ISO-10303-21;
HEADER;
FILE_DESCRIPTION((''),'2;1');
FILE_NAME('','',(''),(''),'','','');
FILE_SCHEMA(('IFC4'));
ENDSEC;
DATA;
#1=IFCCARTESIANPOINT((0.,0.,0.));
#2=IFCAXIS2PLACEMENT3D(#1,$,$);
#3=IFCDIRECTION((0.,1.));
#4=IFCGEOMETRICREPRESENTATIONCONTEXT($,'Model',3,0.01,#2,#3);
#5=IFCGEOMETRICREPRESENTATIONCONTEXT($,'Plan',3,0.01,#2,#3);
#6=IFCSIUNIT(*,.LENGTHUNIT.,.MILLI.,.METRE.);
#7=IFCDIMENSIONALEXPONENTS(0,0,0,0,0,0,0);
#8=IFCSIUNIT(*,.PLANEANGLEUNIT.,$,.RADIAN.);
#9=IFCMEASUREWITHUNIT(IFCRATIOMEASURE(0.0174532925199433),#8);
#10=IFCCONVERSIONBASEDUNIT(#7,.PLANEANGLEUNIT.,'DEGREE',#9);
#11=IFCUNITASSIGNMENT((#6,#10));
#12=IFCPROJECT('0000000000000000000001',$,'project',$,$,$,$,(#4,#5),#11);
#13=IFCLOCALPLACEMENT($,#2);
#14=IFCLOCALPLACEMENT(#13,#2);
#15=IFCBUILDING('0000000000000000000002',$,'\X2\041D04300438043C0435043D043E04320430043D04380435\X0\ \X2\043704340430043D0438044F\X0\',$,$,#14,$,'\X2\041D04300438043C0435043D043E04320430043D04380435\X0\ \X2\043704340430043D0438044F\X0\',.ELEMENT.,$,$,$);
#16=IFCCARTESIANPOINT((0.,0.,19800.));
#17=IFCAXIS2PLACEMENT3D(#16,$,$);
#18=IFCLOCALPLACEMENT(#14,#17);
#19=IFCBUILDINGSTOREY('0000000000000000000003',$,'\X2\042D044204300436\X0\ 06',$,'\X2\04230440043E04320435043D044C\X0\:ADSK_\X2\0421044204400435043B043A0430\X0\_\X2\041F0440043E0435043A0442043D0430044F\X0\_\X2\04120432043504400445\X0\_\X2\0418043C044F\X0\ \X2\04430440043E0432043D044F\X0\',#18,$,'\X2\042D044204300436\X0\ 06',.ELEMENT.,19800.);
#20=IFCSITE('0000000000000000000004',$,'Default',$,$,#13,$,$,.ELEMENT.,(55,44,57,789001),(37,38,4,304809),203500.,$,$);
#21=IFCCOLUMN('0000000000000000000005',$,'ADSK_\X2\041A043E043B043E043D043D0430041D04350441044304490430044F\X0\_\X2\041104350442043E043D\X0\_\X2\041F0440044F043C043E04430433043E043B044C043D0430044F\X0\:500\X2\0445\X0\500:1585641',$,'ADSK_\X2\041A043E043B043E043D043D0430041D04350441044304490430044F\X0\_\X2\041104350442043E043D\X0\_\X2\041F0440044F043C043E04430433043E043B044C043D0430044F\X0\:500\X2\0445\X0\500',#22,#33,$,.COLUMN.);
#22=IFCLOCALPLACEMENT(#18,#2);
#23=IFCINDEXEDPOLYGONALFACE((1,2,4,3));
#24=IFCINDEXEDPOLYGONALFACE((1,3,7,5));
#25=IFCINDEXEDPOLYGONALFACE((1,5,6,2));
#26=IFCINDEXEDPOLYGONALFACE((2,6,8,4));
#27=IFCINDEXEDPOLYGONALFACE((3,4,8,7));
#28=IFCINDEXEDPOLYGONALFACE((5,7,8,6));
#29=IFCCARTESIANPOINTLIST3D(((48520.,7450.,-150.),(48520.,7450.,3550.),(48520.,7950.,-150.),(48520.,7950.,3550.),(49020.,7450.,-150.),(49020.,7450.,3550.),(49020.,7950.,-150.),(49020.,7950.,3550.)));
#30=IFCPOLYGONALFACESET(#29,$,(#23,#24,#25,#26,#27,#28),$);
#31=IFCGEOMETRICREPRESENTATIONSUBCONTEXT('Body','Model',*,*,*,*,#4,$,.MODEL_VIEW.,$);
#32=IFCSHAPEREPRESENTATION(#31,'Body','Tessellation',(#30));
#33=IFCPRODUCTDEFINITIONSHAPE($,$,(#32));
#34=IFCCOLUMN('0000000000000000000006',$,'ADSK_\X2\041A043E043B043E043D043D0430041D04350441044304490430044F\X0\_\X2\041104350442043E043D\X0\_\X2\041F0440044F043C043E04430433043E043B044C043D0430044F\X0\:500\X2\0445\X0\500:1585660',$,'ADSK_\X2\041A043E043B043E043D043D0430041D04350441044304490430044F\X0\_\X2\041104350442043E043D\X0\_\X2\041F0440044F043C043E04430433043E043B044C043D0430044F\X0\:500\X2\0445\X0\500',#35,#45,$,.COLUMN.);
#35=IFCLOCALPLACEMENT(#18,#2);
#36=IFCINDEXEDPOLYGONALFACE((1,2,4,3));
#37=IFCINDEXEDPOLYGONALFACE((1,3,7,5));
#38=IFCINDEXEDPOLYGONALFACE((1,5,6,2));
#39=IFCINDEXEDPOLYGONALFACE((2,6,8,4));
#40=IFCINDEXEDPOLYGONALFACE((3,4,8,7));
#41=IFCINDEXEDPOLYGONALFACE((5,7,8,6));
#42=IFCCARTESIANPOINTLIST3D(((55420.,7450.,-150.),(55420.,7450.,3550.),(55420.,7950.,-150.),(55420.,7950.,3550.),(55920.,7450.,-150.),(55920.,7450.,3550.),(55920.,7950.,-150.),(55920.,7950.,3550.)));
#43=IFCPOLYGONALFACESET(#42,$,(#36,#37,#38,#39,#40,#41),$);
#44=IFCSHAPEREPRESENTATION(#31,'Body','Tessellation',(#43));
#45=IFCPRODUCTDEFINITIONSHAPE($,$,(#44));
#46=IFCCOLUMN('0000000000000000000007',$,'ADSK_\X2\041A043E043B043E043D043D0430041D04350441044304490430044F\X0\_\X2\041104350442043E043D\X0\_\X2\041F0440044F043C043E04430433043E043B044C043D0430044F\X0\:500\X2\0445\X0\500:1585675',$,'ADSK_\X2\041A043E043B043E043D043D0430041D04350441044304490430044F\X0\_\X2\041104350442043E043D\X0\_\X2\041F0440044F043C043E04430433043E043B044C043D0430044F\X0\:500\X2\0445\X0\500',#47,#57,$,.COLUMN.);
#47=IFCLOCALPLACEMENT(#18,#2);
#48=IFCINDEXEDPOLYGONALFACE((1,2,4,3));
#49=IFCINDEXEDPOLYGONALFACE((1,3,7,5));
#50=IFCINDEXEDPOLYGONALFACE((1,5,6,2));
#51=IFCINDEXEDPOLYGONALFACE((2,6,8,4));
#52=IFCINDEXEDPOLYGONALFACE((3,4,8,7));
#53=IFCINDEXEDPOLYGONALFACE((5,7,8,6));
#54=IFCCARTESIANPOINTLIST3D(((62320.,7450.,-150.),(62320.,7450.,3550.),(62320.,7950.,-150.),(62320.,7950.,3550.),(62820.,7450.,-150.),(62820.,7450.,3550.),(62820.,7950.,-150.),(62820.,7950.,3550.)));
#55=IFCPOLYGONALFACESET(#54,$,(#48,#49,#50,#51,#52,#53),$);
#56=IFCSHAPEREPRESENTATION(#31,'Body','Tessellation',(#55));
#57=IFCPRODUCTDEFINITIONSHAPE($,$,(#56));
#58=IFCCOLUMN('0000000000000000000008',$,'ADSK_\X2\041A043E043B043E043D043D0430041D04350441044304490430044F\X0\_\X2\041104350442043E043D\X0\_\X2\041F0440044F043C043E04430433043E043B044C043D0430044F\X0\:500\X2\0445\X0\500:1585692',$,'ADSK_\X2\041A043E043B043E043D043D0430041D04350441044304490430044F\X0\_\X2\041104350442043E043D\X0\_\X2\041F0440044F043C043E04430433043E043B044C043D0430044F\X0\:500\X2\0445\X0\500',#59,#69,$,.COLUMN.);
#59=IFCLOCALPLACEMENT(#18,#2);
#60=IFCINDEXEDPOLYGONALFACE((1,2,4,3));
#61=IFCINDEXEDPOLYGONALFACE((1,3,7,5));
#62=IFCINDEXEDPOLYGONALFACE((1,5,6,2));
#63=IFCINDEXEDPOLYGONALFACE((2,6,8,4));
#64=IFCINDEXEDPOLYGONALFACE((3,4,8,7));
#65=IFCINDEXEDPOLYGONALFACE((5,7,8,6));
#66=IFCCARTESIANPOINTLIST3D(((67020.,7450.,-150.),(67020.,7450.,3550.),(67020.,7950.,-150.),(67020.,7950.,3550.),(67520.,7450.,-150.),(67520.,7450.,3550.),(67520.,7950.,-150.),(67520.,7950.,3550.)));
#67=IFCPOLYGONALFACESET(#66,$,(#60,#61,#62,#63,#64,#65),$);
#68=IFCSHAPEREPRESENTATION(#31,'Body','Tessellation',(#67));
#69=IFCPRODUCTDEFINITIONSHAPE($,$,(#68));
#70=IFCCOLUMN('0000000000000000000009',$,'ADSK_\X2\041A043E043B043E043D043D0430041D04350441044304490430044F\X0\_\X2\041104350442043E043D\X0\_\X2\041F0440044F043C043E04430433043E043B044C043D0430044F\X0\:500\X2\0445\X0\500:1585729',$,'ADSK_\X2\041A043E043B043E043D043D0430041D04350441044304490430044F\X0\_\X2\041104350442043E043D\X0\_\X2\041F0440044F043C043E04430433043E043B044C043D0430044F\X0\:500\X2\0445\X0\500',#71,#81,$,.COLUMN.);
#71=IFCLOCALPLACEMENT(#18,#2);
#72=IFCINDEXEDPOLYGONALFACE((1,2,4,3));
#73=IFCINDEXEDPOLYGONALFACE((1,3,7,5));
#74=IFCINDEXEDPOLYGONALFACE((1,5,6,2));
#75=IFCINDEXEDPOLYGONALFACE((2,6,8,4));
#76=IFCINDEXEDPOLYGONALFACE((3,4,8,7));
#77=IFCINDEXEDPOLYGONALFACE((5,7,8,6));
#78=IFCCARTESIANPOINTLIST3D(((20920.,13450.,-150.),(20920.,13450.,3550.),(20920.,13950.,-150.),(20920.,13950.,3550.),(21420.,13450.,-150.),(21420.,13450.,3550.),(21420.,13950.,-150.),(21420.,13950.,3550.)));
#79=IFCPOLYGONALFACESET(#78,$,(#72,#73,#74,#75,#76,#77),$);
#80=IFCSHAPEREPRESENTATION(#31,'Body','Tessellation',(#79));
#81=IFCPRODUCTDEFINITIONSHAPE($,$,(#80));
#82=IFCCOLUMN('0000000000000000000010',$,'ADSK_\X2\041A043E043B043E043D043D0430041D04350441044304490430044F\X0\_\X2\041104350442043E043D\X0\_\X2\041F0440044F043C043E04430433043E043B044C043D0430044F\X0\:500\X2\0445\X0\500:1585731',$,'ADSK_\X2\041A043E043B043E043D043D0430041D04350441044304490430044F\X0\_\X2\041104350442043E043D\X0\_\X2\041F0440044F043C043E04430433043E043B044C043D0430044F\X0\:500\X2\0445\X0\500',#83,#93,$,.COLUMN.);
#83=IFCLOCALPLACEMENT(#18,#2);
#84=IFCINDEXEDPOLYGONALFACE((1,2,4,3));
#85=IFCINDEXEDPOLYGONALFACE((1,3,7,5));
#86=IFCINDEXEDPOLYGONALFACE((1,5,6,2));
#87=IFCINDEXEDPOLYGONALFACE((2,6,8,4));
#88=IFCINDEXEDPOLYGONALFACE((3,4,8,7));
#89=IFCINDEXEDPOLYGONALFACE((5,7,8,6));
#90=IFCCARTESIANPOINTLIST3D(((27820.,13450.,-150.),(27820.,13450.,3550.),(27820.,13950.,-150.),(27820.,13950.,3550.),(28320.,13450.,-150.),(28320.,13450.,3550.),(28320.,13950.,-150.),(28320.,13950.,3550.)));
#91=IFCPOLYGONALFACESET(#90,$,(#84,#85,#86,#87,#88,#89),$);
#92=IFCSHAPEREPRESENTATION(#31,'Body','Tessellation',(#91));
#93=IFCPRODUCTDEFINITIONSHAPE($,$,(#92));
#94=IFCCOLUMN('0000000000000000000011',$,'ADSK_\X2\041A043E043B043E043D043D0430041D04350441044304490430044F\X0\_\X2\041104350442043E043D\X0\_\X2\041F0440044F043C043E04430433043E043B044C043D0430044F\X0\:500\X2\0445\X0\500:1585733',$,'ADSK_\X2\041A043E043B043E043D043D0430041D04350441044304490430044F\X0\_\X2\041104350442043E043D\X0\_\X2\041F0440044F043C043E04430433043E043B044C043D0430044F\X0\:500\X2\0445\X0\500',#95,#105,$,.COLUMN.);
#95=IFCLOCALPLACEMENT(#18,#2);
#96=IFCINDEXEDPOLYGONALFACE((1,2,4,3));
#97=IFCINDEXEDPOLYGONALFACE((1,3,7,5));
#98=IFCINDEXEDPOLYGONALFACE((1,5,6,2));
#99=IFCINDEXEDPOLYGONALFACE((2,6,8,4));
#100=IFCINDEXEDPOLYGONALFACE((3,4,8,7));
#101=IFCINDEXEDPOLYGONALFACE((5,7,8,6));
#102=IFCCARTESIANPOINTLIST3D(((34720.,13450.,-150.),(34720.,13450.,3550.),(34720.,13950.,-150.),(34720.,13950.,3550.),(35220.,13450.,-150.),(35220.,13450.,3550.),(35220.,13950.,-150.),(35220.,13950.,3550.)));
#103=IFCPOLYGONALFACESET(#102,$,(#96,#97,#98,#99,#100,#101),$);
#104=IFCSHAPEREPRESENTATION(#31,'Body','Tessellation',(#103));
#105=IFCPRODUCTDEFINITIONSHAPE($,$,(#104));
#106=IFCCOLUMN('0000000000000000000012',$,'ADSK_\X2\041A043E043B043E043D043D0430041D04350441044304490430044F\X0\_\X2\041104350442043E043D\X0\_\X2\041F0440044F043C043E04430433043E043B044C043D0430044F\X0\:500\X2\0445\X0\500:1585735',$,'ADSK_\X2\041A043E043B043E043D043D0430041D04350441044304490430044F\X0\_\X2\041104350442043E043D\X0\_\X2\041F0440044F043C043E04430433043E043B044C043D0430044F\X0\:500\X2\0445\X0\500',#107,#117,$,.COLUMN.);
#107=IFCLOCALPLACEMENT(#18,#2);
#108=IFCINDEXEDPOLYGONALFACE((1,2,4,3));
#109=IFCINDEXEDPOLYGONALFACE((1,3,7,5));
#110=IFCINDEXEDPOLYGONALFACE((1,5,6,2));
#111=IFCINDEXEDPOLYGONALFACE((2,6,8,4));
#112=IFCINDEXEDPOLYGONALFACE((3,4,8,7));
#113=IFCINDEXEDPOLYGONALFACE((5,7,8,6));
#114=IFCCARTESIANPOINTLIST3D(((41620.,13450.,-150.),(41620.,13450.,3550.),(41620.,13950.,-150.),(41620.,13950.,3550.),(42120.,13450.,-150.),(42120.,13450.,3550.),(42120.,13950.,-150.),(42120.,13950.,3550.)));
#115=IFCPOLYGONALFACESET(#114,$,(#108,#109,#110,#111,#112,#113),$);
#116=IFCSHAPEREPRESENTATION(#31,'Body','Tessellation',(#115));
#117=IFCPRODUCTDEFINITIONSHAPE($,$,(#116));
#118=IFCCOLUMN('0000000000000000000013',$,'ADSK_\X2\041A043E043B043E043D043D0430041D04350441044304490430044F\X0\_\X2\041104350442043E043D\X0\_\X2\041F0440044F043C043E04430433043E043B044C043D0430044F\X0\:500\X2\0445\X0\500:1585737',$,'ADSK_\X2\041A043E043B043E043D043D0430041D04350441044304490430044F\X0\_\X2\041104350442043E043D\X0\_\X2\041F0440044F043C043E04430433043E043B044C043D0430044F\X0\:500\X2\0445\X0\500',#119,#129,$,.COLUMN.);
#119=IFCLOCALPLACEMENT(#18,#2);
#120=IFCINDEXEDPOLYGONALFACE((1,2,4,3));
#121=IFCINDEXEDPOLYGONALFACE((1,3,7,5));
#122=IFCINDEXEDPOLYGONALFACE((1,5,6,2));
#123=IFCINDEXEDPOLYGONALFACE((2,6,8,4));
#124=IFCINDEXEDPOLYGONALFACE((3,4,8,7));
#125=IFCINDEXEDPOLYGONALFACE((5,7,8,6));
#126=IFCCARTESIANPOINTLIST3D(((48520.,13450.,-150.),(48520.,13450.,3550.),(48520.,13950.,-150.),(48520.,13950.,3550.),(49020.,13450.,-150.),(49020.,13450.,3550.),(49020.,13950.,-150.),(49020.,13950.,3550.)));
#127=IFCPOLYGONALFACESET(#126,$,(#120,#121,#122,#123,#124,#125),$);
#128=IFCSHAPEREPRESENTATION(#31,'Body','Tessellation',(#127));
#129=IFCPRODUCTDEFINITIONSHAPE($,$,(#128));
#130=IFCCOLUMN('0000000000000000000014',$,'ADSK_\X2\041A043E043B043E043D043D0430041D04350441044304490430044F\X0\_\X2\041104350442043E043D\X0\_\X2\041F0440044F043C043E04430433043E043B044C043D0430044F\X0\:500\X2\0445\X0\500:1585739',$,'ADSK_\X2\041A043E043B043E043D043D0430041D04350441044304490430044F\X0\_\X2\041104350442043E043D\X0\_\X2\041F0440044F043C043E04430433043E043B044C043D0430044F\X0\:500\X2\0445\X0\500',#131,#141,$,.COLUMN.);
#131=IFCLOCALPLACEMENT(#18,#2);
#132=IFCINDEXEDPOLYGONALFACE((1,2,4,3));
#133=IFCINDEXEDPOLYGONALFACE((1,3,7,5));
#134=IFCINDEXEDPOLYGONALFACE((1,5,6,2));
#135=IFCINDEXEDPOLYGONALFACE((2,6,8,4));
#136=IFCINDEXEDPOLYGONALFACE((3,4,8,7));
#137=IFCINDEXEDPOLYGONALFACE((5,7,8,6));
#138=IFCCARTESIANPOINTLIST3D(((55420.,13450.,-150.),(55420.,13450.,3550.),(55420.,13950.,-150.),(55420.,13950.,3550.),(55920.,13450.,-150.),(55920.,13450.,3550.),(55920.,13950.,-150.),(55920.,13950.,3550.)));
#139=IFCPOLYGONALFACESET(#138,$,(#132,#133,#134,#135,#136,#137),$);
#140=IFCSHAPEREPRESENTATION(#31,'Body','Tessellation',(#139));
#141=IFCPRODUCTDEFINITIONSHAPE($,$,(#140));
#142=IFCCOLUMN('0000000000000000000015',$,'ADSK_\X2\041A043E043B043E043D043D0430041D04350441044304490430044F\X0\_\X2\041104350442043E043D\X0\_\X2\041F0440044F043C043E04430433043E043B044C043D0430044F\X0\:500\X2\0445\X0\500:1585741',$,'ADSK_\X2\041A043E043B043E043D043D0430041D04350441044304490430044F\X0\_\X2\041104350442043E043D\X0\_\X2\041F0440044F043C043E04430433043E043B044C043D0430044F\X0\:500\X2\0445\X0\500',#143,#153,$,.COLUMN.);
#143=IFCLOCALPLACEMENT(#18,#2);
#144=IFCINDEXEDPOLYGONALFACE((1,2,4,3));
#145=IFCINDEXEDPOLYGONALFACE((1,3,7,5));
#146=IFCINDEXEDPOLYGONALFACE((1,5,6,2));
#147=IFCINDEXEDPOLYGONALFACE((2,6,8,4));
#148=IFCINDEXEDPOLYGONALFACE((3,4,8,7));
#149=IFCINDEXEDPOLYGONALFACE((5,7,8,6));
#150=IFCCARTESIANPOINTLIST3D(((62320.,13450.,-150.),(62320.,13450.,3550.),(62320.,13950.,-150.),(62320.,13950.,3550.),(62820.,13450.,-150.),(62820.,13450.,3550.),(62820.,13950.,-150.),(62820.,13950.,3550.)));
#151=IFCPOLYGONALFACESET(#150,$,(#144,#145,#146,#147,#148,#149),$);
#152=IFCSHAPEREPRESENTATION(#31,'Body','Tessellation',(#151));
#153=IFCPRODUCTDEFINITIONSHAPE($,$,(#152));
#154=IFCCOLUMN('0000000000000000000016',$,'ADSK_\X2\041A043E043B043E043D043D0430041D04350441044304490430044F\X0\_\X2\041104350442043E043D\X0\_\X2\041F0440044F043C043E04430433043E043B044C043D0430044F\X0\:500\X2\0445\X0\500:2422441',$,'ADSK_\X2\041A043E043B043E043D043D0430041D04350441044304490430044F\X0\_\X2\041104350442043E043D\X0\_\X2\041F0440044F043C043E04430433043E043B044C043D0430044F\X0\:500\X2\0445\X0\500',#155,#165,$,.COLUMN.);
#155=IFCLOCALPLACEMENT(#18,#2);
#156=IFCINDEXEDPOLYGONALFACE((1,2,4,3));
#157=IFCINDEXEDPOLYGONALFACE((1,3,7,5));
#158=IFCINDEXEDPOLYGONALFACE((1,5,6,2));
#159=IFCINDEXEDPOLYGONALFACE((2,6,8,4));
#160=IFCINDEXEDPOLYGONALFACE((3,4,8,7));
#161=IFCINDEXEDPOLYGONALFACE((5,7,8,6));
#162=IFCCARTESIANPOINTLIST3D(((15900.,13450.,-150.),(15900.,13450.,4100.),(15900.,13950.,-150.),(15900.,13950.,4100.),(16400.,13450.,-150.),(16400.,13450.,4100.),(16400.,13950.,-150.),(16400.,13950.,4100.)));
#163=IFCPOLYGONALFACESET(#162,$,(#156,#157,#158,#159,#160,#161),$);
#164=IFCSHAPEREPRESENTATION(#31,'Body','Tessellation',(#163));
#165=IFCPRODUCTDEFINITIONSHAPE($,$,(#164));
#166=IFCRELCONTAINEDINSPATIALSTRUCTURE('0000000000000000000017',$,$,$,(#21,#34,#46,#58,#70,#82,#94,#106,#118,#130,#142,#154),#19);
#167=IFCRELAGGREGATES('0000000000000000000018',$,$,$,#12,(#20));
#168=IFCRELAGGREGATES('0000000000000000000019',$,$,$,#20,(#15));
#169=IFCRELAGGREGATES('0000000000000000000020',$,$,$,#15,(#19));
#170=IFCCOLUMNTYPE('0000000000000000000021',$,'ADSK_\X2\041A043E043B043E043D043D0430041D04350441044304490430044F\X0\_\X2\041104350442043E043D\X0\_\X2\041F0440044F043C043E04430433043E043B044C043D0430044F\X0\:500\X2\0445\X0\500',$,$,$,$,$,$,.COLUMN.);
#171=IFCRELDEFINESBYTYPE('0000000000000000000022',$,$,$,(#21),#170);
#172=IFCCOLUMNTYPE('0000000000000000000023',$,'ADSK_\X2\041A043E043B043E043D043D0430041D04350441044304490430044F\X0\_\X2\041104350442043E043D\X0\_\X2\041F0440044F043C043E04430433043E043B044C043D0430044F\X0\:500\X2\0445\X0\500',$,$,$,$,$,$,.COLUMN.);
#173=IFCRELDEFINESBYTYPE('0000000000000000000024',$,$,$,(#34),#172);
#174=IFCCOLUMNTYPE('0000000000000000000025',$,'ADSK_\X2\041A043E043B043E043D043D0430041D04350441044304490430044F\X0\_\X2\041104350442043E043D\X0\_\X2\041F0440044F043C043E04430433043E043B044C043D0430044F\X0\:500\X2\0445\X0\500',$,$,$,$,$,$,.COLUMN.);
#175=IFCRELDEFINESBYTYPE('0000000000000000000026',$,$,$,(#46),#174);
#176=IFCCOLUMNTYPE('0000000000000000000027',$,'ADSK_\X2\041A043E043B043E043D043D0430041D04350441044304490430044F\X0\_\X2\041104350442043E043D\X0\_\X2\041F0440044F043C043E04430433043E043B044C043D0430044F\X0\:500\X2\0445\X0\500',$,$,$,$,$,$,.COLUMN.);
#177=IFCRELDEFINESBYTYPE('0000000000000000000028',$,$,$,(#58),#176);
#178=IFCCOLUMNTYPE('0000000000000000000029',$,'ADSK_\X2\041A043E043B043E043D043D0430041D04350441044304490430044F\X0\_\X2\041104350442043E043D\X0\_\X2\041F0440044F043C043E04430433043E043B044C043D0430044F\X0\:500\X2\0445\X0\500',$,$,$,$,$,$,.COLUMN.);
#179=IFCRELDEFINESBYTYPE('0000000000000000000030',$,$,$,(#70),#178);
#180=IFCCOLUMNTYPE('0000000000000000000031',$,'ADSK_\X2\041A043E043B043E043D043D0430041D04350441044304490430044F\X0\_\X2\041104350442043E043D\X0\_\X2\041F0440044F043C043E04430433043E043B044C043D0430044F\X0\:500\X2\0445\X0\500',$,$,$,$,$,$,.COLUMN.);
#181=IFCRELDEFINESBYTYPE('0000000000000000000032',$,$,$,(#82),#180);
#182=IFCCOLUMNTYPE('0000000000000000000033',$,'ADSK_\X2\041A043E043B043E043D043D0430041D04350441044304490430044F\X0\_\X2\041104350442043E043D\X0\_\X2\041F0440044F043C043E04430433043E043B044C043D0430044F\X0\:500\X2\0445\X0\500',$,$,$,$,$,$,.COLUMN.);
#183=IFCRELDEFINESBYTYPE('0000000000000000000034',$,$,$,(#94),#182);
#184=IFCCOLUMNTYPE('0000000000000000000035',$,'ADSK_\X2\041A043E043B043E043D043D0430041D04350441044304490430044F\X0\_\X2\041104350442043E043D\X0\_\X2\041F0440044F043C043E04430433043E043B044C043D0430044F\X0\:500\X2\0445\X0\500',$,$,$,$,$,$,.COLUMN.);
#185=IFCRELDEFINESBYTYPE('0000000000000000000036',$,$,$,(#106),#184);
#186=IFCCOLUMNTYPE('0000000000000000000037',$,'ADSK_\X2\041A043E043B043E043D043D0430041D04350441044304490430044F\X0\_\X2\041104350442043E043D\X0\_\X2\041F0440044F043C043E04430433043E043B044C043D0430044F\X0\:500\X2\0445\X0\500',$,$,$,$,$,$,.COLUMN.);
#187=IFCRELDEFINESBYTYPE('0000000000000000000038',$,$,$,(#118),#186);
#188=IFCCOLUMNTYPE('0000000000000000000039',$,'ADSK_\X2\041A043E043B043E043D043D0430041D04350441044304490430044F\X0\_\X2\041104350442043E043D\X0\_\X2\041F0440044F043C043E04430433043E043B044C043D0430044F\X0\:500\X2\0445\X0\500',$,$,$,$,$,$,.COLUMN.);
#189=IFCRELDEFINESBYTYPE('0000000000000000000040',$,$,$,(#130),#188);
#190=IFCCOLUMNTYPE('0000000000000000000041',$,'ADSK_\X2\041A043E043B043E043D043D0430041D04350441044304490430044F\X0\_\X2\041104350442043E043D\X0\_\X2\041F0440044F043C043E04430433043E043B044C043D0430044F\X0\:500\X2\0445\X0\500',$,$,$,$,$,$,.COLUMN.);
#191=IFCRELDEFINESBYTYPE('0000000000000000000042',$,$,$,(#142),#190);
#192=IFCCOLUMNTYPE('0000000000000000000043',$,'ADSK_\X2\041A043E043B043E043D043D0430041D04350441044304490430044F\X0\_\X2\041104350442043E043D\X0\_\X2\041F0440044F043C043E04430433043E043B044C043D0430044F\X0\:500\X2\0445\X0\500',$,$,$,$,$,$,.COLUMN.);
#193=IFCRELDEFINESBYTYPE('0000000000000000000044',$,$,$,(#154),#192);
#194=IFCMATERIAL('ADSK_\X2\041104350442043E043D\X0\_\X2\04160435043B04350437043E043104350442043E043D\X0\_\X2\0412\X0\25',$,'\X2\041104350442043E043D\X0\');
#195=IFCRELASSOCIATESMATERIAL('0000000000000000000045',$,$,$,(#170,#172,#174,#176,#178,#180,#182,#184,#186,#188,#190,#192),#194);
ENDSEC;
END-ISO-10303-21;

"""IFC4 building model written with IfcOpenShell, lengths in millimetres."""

from ifc_helpers import new_model, entity, si_unit, converted_unit, direction, frame, origin, place, context, subcontext, project, spatial, indexed_curve, outline, extrude, source, transform, mapped, material, type_object, type_shapes, element, save


model = new_model("IFC4")

# Units and contexts
model_context = context("Model", 3, precision=0.01, world=origin(), true_north=direction((0.0, 1.0)))
plan_context = context("Plan", 3, precision=0.01, world=origin(), true_north=direction((0.0, 1.0)))
body_context = subcontext(model_context, "Body", "Model", "MODEL_VIEW")
ifc_project = project(units=[si_unit("LENGTHUNIT", "METRE", prefix="MILLI"), converted_unit("PLANEANGLEUNIT", "DEGREE", entity("IfcRatioMeasure", 0.0174532925199433), si_unit("PLANEANGLEUNIT", "RADIAN"), dimensions=[0, 0, 0, 0, 0, 0, 0])], contexts=[model_context, plan_context])

# Site, building, storey
site_placement = place(None, origin())
site = spatial("IfcSite", under=ifc_project, at=site_placement, Name="Default", CompositionType="ELEMENT", RefLatitude=(55, 44, 57, 789001), RefLongitude=(37, 38, 4, 304809), RefElevation=203500.0)
building_placement = place(site_placement, origin())
building = spatial("IfcBuilding", under=site, at=building_placement, Name="Наименование здания", LongName="Наименование здания", CompositionType="ELEMENT")
storey_placement = place(building_placement, frame((0.0, 0.0, 19800.0)))
storey = spatial("IfcBuildingStorey", under=building, at=storey_placement, Name="Этаж 06", ObjectType="Уровень:ADSK_Стрелка_Проектная_Вверх_Имя уровня", LongName="Этаж 06", CompositionType="ELEMENT", Elevation=19800.0)

# Columns
ifc_material = material(Name="ADSK_Бетон_Железобетон_В25", Category="Бетон")
placement_1 = place(storey_placement, frame((0.0, 0.0, -19800.0)))
column_type_1 = type_object("IfcColumnType", Name="ADSK_КолоннаНесущая_Бетон_Прямоугольная:500х500", PredefinedType="COLUMN", material=ifc_material)
shared_shape_1 = source(origin(), body_context, "Body", "SweptSolid", [
    extrude(outline(indexed_curve([(-250.0, -250.0), (250.0, -250.0), (250.0, 250.0), (-250.0, 250.0), (-250.0, -250.0)], self_intersect=False)), frame((48770.0, 7700.0, 19650.0), z_axis=(0.0, 0.0, 1.0), x_axis=(0.0, -1.0, 0.0)), (0.0, 0.0, 1.0), 3700.0),
])
type_shapes(column_type_1, [shared_shape_1])
element("IfcColumn", 1, at=placement_1, inside=storey, type_object=column_type_1, Name="ADSK_КолоннаНесущая_Бетон_Прямоугольная:500х500:1585641", ObjectType="ADSK_КолоннаНесущая_Бетон_Прямоугольная:500х500", PredefinedType="COLUMN", context=body_context, shape_type="MappedRepresentation", body=[
    mapped(shared_shape_1, transform((0.0, 0.0, 0.0), scale=1.0)),
])
column_type_2 = type_object("IfcColumnType", Name="ADSK_КолоннаНесущая_Бетон_Прямоугольная:500х500", PredefinedType="COLUMN", material=ifc_material)
shared_shape_2 = source(origin(), body_context, "Body", "SweptSolid", [
    extrude(outline(indexed_curve([(-250.0, -250.0), (250.0, -250.0), (250.0, 250.0), (-250.0, 250.0), (-250.0, -250.0)], self_intersect=False)), frame((55670.0, 7700.0, 19650.0), z_axis=(0.0, 0.0, 1.0), x_axis=(0.0, -1.0, 0.0)), (0.0, 0.0, 1.0), 3700.0),
])
type_shapes(column_type_2, [shared_shape_2])
element("IfcColumn", 2, at=placement_1, inside=storey, type_object=column_type_2, Name="ADSK_КолоннаНесущая_Бетон_Прямоугольная:500х500:1585660", ObjectType="ADSK_КолоннаНесущая_Бетон_Прямоугольная:500х500", PredefinedType="COLUMN", context=body_context, shape_type="MappedRepresentation", body=[
    mapped(shared_shape_2, transform((0.0, 0.0, 0.0), scale=1.0)),
])
column_type_3 = type_object("IfcColumnType", Name="ADSK_КолоннаНесущая_Бетон_Прямоугольная:500х500", PredefinedType="COLUMN", material=ifc_material)
shared_shape_3 = source(origin(), body_context, "Body", "SweptSolid", [
    extrude(outline(indexed_curve([(-250.0, -250.0), (250.0, -250.0), (250.0, 250.0), (-250.0, 250.0), (-250.0, -250.0)], self_intersect=False)), frame((62570.0, 7700.0, 19650.0), z_axis=(0.0, 0.0, 1.0), x_axis=(0.0, -1.0, 0.0)), (0.0, 0.0, 1.0), 3700.0),
])
type_shapes(column_type_3, [shared_shape_3])
element("IfcColumn", 3, at=placement_1, inside=storey, type_object=column_type_3, Name="ADSK_КолоннаНесущая_Бетон_Прямоугольная:500х500:1585675", ObjectType="ADSK_КолоннаНесущая_Бетон_Прямоугольная:500х500", PredefinedType="COLUMN", context=body_context, shape_type="MappedRepresentation", body=[
    mapped(shared_shape_3, transform((0.0, 0.0, 0.0), scale=1.0)),
])
column_type_4 = type_object("IfcColumnType", Name="ADSK_КолоннаНесущая_Бетон_Прямоугольная:500х500", PredefinedType="COLUMN", material=ifc_material)
shared_shape_4 = source(origin(), body_context, "Body", "SweptSolid", [
    extrude(outline(indexed_curve([(-250.0, -250.0), (250.0, -250.0), (250.0, 250.0), (-250.0, 250.0), (-250.0, -250.0)], self_intersect=False)), frame((67270.0, 7700.0, 19650.0), z_axis=(0.0, 0.0, 1.0), x_axis=(0.0, -1.0, 0.0)), (0.0, 0.0, 1.0), 3700.0),
])
type_shapes(column_type_4, [shared_shape_4])
element("IfcColumn", 4, at=placement_1, inside=storey, type_object=column_type_4, Name="ADSK_КолоннаНесущая_Бетон_Прямоугольная:500х500:1585692", ObjectType="ADSK_КолоннаНесущая_Бетон_Прямоугольная:500х500", PredefinedType="COLUMN", context=body_context, shape_type="MappedRepresentation", body=[
    mapped(shared_shape_4, transform((0.0, 0.0, 0.0), scale=1.0)),
])
column_type_5 = type_object("IfcColumnType", Name="ADSK_КолоннаНесущая_Бетон_Прямоугольная:500х500", PredefinedType="COLUMN", material=ifc_material)
shared_shape_5 = source(origin(), body_context, "Body", "SweptSolid", [
    extrude(outline(indexed_curve([(-250.0, -250.0), (250.0, -250.0), (250.0, 250.0), (-250.0, 250.0), (-250.0, -250.0)], self_intersect=False)), frame((21170.0, 13700.0, 19650.0), z_axis=(0.0, 0.0, 1.0), x_axis=(0.0, -1.0, 0.0)), (0.0, 0.0, 1.0), 3700.0),
])
type_shapes(column_type_5, [shared_shape_5])
element("IfcColumn", 5, at=placement_1, inside=storey, type_object=column_type_5, Name="ADSK_КолоннаНесущая_Бетон_Прямоугольная:500х500:1585729", ObjectType="ADSK_КолоннаНесущая_Бетон_Прямоугольная:500х500", PredefinedType="COLUMN", context=body_context, shape_type="MappedRepresentation", body=[
    mapped(shared_shape_5, transform((0.0, 0.0, 0.0), scale=1.0)),
])
column_type_6 = type_object("IfcColumnType", Name="ADSK_КолоннаНесущая_Бетон_Прямоугольная:500х500", PredefinedType="COLUMN", material=ifc_material)
shared_shape_6 = source(origin(), body_context, "Body", "SweptSolid", [
    extrude(outline(indexed_curve([(-250.0, -250.0), (250.0, -250.0), (250.0, 250.0), (-250.0, 250.0), (-250.0, -250.0)], self_intersect=False)), frame((28070.0, 13700.0, 19650.0), z_axis=(0.0, 0.0, 1.0), x_axis=(0.0, -1.0, 0.0)), (0.0, 0.0, 1.0), 3700.0),
])
type_shapes(column_type_6, [shared_shape_6])
element("IfcColumn", 6, at=placement_1, inside=storey, type_object=column_type_6, Name="ADSK_КолоннаНесущая_Бетон_Прямоугольная:500х500:1585731", ObjectType="ADSK_КолоннаНесущая_Бетон_Прямоугольная:500х500", PredefinedType="COLUMN", context=body_context, shape_type="MappedRepresentation", body=[
    mapped(shared_shape_6, transform((0.0, 0.0, 0.0), scale=1.0)),
])
column_type_7 = type_object("IfcColumnType", Name="ADSK_КолоннаНесущая_Бетон_Прямоугольная:500х500", PredefinedType="COLUMN", material=ifc_material)
shared_shape_7 = source(origin(), body_context, "Body", "SweptSolid", [
    extrude(outline(indexed_curve([(-250.0, -250.0), (250.0, -250.0), (250.0, 250.0), (-250.0, 250.0), (-250.0, -250.0)], self_intersect=False)), frame((34970.0, 13700.0, 19650.0), z_axis=(0.0, 0.0, 1.0), x_axis=(0.0, -1.0, 0.0)), (0.0, 0.0, 1.0), 3700.0),
])
type_shapes(column_type_7, [shared_shape_7])
element("IfcColumn", 7, at=placement_1, inside=storey, type_object=column_type_7, Name="ADSK_КолоннаНесущая_Бетон_Прямоугольная:500х500:1585733", ObjectType="ADSK_КолоннаНесущая_Бетон_Прямоугольная:500х500", PredefinedType="COLUMN", context=body_context, shape_type="MappedRepresentation", body=[
    mapped(shared_shape_7, transform((0.0, 0.0, 0.0), scale=1.0)),
])
column_type_8 = type_object("IfcColumnType", Name="ADSK_КолоннаНесущая_Бетон_Прямоугольная:500х500", PredefinedType="COLUMN", material=ifc_material)
shared_shape_8 = source(origin(), body_context, "Body", "SweptSolid", [
    extrude(outline(indexed_curve([(-250.0, -250.0), (250.0, -250.0), (250.0, 250.0), (-250.0, 250.0), (-250.0, -250.0)], self_intersect=False)), frame((41870.0, 13700.0, 19650.0), z_axis=(0.0, 0.0, 1.0), x_axis=(0.0, -1.0, 0.0)), (0.0, 0.0, 1.0), 3700.0),
])
type_shapes(column_type_8, [shared_shape_8])
element("IfcColumn", 8, at=placement_1, inside=storey, type_object=column_type_8, Name="ADSK_КолоннаНесущая_Бетон_Прямоугольная:500х500:1585735", ObjectType="ADSK_КолоннаНесущая_Бетон_Прямоугольная:500х500", PredefinedType="COLUMN", context=body_context, shape_type="MappedRepresentation", body=[
    mapped(shared_shape_8, transform((0.0, 0.0, 0.0), scale=1.0)),
])
column_type_9 = type_object("IfcColumnType", Name="ADSK_КолоннаНесущая_Бетон_Прямоугольная:500х500", PredefinedType="COLUMN", material=ifc_material)
shared_shape_9 = source(origin(), body_context, "Body", "SweptSolid", [
    extrude(outline(indexed_curve([(-250.0, -250.0), (250.0, -250.0), (250.0, 250.0), (-250.0, 250.0), (-250.0, -250.0)], self_intersect=False)), frame((48770.0, 13700.0, 19650.0), z_axis=(0.0, 0.0, 1.0), x_axis=(0.0, -1.0, 0.0)), (0.0, 0.0, 1.0), 3700.0),
])
type_shapes(column_type_9, [shared_shape_9])
element("IfcColumn", 9, at=placement_1, inside=storey, type_object=column_type_9, Name="ADSK_КолоннаНесущая_Бетон_Прямоугольная:500х500:1585737", ObjectType="ADSK_КолоннаНесущая_Бетон_Прямоугольная:500х500", PredefinedType="COLUMN", context=body_context, shape_type="MappedRepresentation", body=[
    mapped(shared_shape_9, transform((0.0, 0.0, 0.0), scale=1.0)),
])
column_type_10 = type_object("IfcColumnType", Name="ADSK_КолоннаНесущая_Бетон_Прямоугольная:500х500", PredefinedType="COLUMN", material=ifc_material)
shared_shape_10 = source(origin(), body_context, "Body", "SweptSolid", [
    extrude(outline(indexed_curve([(-250.0, -250.0), (250.0, -250.0), (250.0, 250.0), (-250.0, 250.0), (-250.0, -250.0)], self_intersect=False)), frame((55670.0, 13700.0, 19650.0), z_axis=(0.0, 0.0, 1.0), x_axis=(0.0, -1.0, 0.0)), (0.0, 0.0, 1.0), 3700.0),
])
type_shapes(column_type_10, [shared_shape_10])
element("IfcColumn", 10, at=placement_1, inside=storey, type_object=column_type_10, Name="ADSK_КолоннаНесущая_Бетон_Прямоугольная:500х500:1585739", ObjectType="ADSK_КолоннаНесущая_Бетон_Прямоугольная:500х500", PredefinedType="COLUMN", context=body_context, shape_type="MappedRepresentation", body=[
    mapped(shared_shape_10, transform((0.0, 0.0, 0.0), scale=1.0)),
])
column_type_11 = type_object("IfcColumnType", Name="ADSK_КолоннаНесущая_Бетон_Прямоугольная:500х500", PredefinedType="COLUMN", material=ifc_material)
shared_shape_11 = source(origin(), body_context, "Body", "SweptSolid", [
    extrude(outline(indexed_curve([(-250.0, -250.0), (250.0, -250.0), (250.0, 250.0), (-250.0, 250.0), (-250.0, -250.0)], self_intersect=False)), frame((62570.0, 13700.0, 19650.0), z_axis=(0.0, 0.0, 1.0), x_axis=(0.0, -1.0, 0.0)), (0.0, 0.0, 1.0), 3700.0),
])
type_shapes(column_type_11, [shared_shape_11])
element("IfcColumn", 11, at=placement_1, inside=storey, type_object=column_type_11, Name="ADSK_КолоннаНесущая_Бетон_Прямоугольная:500х500:1585741", ObjectType="ADSK_КолоннаНесущая_Бетон_Прямоугольная:500х500", PredefinedType="COLUMN", context=body_context, shape_type="MappedRepresentation", body=[
    mapped(shared_shape_11, transform((0.0, 0.0, 0.0), scale=1.0)),
])
column_type_12 = type_object("IfcColumnType", Name="ADSK_КолоннаНесущая_Бетон_Прямоугольная:500х500", PredefinedType="COLUMN", material=ifc_material)
shared_shape_12 = source(origin(), body_context, "Body", "SweptSolid", [
    extrude(outline(indexed_curve([(-250.0, -250.0), (250.0, -250.0), (250.0, 250.0), (-250.0, 250.0), (-250.0, -250.0)], self_intersect=False)), frame((16150.0, 13700.0, 19650.0), z_axis=(0.0, 0.0, 1.0), x_axis=(0.0, -1.0, 0.0)), (0.0, 0.0, 1.0), 4250.0),
])
type_shapes(column_type_12, [shared_shape_12])
element("IfcColumn", 12, at=placement_1, inside=storey, type_object=column_type_12, Name="ADSK_КолоннаНесущая_Бетон_Прямоугольная:500х500:2422441", ObjectType="ADSK_КолоннаНесущая_Бетон_Прямоугольная:500х500", PredefinedType="COLUMN", context=body_context, shape_type="MappedRepresentation", body=[
    mapped(shared_shape_12, transform((0.0, 0.0, 0.0), scale=1.0)),
])

save(model, "model.ifc")
